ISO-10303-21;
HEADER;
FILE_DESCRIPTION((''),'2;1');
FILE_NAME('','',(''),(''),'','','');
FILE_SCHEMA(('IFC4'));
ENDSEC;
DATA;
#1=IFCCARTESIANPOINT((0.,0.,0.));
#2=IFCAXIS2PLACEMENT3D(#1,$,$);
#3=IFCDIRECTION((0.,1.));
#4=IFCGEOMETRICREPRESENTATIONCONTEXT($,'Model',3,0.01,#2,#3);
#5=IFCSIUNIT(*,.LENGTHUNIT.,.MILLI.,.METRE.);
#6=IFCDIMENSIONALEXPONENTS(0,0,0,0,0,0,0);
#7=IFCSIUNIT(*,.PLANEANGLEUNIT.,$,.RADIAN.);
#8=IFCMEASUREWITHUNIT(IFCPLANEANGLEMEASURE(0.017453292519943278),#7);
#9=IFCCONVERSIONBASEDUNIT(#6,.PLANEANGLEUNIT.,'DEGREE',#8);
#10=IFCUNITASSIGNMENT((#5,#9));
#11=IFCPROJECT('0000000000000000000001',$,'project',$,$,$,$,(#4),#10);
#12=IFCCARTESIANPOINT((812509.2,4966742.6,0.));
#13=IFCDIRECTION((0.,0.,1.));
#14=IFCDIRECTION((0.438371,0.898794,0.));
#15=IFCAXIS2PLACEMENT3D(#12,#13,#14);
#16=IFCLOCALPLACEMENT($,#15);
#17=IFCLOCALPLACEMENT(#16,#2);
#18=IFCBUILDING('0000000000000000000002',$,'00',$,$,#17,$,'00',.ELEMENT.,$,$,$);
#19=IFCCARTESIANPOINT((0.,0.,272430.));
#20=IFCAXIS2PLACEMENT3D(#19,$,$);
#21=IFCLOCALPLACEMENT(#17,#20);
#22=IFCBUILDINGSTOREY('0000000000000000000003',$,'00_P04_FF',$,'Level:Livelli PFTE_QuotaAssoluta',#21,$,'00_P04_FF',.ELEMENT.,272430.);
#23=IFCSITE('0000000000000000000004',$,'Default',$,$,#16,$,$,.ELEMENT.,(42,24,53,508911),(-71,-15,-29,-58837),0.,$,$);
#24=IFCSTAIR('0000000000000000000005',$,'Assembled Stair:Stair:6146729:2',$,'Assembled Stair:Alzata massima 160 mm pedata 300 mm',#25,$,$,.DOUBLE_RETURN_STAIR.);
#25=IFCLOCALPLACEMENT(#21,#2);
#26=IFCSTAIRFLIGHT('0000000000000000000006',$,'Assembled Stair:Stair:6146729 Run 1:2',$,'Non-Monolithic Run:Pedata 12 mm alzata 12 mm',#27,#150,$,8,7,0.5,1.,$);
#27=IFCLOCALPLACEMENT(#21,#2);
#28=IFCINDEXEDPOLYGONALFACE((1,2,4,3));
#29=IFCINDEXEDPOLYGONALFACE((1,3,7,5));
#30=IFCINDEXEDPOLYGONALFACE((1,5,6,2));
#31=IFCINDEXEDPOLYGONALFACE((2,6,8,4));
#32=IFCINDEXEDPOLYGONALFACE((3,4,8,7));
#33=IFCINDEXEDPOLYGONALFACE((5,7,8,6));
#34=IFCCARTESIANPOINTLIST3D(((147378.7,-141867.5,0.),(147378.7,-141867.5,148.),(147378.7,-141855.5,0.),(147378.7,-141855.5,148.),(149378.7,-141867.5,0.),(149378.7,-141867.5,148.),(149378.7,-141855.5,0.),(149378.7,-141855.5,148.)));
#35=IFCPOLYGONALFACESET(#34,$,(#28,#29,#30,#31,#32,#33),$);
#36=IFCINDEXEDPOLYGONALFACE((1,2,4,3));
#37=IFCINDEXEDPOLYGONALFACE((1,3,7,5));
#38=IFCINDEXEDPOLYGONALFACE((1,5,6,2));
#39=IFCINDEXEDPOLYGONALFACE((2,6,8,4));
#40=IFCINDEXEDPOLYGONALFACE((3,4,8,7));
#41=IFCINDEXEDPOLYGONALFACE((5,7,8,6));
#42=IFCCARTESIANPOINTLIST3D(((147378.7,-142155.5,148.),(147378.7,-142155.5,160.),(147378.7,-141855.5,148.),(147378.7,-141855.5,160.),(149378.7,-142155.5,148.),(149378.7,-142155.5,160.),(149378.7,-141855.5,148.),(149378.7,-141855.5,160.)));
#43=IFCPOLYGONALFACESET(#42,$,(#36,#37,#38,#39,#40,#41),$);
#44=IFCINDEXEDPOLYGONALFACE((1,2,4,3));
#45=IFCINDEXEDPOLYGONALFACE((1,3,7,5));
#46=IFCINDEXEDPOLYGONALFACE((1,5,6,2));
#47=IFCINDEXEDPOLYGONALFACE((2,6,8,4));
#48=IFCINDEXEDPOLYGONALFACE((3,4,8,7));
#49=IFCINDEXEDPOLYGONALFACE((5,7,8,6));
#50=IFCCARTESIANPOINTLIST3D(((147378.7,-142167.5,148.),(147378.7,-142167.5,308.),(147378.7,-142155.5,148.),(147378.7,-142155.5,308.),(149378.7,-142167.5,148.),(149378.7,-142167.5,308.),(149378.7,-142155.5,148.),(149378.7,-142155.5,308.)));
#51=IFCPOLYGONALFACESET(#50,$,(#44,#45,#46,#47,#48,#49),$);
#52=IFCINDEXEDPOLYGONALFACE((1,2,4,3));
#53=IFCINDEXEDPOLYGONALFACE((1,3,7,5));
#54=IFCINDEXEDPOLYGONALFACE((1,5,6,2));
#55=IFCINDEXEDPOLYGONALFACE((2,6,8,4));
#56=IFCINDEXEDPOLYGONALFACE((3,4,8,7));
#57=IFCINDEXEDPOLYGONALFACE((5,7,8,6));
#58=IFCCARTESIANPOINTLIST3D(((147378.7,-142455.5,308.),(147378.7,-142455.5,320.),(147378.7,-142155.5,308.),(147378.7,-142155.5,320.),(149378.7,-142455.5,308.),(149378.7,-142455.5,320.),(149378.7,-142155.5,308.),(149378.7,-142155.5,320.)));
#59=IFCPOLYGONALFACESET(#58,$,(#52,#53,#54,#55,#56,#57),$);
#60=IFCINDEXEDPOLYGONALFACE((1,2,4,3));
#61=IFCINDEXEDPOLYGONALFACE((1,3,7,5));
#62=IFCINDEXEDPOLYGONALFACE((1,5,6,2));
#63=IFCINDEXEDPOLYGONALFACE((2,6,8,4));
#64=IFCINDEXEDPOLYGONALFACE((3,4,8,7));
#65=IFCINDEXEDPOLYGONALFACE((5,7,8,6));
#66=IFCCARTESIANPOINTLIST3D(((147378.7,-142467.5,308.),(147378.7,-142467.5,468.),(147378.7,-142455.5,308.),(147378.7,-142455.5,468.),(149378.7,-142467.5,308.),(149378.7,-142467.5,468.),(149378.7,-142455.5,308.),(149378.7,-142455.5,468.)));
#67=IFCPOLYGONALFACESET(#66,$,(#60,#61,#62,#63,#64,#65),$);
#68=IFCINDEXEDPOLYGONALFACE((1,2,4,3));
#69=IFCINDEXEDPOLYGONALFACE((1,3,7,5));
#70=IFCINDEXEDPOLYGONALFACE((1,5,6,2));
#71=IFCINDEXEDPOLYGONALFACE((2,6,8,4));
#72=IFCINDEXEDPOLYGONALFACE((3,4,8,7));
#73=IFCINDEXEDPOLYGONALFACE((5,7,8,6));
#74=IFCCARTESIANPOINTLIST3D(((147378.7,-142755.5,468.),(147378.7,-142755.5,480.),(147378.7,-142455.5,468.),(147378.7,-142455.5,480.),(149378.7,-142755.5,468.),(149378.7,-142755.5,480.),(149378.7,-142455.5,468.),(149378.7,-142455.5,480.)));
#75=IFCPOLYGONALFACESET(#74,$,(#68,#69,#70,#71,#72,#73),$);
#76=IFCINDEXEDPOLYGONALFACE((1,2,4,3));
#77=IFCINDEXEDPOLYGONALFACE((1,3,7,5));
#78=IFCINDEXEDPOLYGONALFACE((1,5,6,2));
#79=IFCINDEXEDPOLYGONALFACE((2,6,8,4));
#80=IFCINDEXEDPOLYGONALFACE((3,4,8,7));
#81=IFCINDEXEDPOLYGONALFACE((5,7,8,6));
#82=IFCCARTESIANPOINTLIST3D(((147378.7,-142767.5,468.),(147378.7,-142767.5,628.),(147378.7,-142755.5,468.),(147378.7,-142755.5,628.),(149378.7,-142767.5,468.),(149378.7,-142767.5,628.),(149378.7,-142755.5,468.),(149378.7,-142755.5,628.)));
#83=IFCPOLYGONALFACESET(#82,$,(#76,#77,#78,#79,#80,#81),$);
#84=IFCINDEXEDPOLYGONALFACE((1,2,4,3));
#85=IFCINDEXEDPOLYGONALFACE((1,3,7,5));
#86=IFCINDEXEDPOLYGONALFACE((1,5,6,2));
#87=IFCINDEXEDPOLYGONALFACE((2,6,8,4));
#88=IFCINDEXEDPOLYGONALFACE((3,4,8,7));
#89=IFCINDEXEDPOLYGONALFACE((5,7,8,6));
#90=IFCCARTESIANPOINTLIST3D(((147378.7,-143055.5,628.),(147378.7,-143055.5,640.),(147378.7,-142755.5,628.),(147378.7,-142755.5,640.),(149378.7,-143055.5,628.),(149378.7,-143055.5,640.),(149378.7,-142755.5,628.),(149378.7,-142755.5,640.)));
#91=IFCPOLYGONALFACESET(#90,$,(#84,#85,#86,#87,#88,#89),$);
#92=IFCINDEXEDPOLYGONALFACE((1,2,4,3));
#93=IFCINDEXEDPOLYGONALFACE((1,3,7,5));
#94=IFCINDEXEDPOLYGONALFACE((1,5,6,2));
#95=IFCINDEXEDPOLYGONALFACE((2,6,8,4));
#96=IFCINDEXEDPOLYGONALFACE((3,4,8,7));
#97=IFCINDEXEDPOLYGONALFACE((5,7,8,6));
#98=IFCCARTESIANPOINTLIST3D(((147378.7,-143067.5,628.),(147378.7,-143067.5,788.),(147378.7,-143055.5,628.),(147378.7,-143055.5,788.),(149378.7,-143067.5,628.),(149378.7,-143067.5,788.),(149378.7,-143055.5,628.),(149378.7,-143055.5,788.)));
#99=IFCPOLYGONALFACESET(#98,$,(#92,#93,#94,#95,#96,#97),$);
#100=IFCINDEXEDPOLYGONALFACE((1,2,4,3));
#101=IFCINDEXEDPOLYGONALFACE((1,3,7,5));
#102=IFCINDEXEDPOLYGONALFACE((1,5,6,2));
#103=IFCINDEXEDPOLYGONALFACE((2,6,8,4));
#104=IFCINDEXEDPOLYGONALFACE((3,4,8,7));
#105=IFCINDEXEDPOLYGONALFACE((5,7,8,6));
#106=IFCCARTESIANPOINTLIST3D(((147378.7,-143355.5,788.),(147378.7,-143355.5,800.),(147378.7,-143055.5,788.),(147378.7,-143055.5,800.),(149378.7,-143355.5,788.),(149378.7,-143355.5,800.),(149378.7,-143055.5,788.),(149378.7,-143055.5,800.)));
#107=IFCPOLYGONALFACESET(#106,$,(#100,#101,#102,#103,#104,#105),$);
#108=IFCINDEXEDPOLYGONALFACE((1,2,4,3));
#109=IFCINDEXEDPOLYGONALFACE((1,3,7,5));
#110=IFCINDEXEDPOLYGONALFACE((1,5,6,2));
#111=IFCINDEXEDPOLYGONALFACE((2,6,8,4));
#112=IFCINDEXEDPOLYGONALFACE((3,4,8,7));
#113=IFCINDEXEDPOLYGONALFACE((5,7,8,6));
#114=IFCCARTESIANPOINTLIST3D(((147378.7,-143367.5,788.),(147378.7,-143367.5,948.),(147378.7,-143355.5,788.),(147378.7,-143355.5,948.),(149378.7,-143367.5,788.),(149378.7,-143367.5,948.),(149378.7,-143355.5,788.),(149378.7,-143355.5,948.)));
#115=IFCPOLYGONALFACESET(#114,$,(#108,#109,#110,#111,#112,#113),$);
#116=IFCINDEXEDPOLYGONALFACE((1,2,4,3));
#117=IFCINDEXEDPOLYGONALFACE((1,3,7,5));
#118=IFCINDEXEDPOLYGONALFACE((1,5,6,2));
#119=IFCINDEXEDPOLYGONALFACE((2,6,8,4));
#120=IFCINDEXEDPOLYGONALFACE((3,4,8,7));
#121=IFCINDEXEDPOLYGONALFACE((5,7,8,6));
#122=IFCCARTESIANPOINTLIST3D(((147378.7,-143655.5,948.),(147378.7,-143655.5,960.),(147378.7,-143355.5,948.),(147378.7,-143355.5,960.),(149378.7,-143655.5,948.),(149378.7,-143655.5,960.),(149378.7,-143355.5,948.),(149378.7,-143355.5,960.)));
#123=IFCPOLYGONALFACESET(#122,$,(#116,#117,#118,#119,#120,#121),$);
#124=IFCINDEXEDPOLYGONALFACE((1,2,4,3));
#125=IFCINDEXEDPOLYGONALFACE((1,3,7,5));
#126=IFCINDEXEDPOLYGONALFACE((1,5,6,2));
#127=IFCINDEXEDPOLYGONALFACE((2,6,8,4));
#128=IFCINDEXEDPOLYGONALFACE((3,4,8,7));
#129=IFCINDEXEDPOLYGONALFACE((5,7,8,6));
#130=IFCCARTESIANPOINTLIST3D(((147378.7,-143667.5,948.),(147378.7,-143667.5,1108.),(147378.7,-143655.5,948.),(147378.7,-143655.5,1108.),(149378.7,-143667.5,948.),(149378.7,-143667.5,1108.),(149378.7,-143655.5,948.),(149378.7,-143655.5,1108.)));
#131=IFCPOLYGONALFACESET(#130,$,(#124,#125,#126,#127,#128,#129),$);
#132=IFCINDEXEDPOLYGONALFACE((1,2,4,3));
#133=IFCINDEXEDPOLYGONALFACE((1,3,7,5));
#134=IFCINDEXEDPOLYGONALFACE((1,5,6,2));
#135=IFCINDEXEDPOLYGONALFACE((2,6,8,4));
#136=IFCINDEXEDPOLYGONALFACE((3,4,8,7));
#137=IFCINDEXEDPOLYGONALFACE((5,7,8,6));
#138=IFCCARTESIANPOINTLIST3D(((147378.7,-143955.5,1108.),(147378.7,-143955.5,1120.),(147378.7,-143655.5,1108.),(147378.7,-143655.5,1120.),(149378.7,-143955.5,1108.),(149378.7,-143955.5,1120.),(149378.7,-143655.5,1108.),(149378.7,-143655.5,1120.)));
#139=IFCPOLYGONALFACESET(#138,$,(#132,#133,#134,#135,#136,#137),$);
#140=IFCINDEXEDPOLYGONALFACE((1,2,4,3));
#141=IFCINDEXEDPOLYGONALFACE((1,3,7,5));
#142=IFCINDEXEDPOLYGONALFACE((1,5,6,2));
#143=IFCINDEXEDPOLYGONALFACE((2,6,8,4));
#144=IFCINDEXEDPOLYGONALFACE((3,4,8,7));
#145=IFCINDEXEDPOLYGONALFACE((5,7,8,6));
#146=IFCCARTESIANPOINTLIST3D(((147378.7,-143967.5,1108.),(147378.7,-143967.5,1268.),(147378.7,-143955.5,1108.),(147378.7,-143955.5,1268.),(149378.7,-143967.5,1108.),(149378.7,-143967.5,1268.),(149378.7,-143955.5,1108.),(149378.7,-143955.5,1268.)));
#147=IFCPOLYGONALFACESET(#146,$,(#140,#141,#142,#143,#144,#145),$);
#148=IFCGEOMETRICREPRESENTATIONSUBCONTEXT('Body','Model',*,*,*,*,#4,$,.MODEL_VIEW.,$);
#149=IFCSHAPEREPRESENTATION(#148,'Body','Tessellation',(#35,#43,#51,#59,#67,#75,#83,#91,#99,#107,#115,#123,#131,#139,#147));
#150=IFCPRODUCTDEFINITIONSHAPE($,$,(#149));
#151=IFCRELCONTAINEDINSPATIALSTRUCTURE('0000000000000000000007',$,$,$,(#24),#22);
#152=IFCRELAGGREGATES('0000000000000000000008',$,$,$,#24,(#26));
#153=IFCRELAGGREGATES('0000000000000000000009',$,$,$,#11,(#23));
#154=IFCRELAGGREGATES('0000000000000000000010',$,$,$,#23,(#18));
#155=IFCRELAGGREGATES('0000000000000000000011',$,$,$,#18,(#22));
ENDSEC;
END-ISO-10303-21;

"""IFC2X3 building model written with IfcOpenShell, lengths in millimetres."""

from ifc_helpers import new_model, entity, si_unit, converted_unit, direction, frame, origin, origin_2d_with_axis, place, context, subcontext, project, spatial, rectangle, extrude, element, aggregate, save


model = new_model("IFC2X3")

# Units and contexts
model_context = context("Model", 3, precision=0.01, world=origin(), true_north=direction((0.0, 1.0)))
body_context = subcontext(model_context, "Body", "Model", "MODEL_VIEW")
ifc_project = project(units=[si_unit("LENGTHUNIT", "METRE", prefix="MILLI"), converted_unit("PLANEANGLEUNIT", "DEGREE", entity("IfcPlaneAngleMeasure", 0.017453292519943278), si_unit("PLANEANGLEUNIT", "RADIAN"), dimensions=[0, 0, 0, 0, 0, 0, 0])], contexts=[model_context])

# Site, building, storey
site_placement = place(None, frame((812509.2, 4966742.6, 0.0), z_axis=(0.0, 0.0, 1.0), x_axis=(0.438371, 0.898794, 0.0)))
site = spatial("IfcSite", under=ifc_project, at=site_placement, Name="Default", CompositionType="ELEMENT", RefLatitude=(42, 24, 53, 508911), RefLongitude=(-71, -15, -29, -58837), RefElevation=0.0)
building_placement = place(site_placement, origin())
building = spatial("IfcBuilding", under=site, at=building_placement, Name="00", LongName="00", CompositionType="ELEMENT")
storey_placement = place(building_placement, frame((0.0, 0.0, 272430.0)))
storey = spatial("IfcBuildingStorey", under=building, at=storey_placement, Name="00_P04_FF", ObjectType="Level:Livelli PFTE_QuotaAssoluta", LongName="00_P04_FF", CompositionType="ELEMENT", Elevation=272430.0)

# Stair
stair_1_placement = place(storey_placement, origin())
stair_1 = element("IfcStair", 1, at=stair_1_placement, inside=storey, Name="Assembled Stair:Stair:6146729:2", ObjectType="Assembled Stair:Alzata massima 160 mm pedata 300 mm", ShapeType="DOUBLE_RETURN_STAIR")

# Stair flight
stair_flight_1_placement = place(stair_1_placement, origin())
stair_flight_1 = element("IfcStairFlight", 2, at=stair_flight_1_placement, Name="Assembled Stair:Stair:6146729 Run 1:2", ObjectType="Non-Monolithic Run:Pedata 12 mm alzata 12 mm", NumberOfRiser=8, NumberOfTreads=7, RiserHeight=0.5, TreadLength=1.0, context=body_context, shape_type="SweptSolid", body=[
    extrude(rectangle(XDim=2000.0, YDim=12.0, at=origin_2d_with_axis()), frame((148378.7, -141861.5, 0.0)), (0.0, 0.0, 1.0), 148.0),
    extrude(rectangle(XDim=300.0, YDim=2000.0, at=origin_2d_with_axis()), frame((148378.7, -142005.5, 148.0), z_axis=(0.0, 0.0, 1.0), x_axis=(0.0, 1.0, 0.0)), (0.0, 0.0, 1.0), 12.0),
    extrude(rectangle(XDim=2000.0, YDim=12.0, at=origin_2d_with_axis()), frame((148378.7, -142161.5, 148.0)), (0.0, 0.0, 1.0), 160.0),
    extrude(rectangle(XDim=300.0, YDim=2000.0, at=origin_2d_with_axis()), frame((148378.7, -142305.5, 308.0), z_axis=(0.0, 0.0, 1.0), x_axis=(0.0, 1.0, 0.0)), (0.0, 0.0, 1.0), 12.0),
    extrude(rectangle(XDim=2000.0, YDim=12.0, at=origin_2d_with_axis()), frame((148378.7, -142461.5, 308.0)), (0.0, 0.0, 1.0), 160.0),
    extrude(rectangle(XDim=300.0, YDim=2000.0, at=origin_2d_with_axis()), frame((148378.7, -142605.5, 468.0), z_axis=(0.0, 0.0, 1.0), x_axis=(0.0, 1.0, 0.0)), (0.0, 0.0, 1.0), 12.0),
    extrude(rectangle(XDim=2000.0, YDim=12.0, at=origin_2d_with_axis()), frame((148378.7, -142761.5, 468.0)), (0.0, 0.0, 1.0), 160.0),
    extrude(rectangle(XDim=300.0, YDim=2000.0, at=origin_2d_with_axis()), frame((148378.7, -142905.5, 628.0), z_axis=(0.0, 0.0, 1.0), x_axis=(0.0, 1.0, 0.0)), (0.0, 0.0, 1.0), 12.0),
    extrude(rectangle(XDim=2000.0, YDim=12.0, at=origin_2d_with_axis()), frame((148378.7, -143061.5, 628.0)), (0.0, 0.0, 1.0), 160.0),
    extrude(rectangle(XDim=300.0, YDim=2000.0, at=origin_2d_with_axis()), frame((148378.7, -143205.5, 788.0), z_axis=(0.0, 0.0, 1.0), x_axis=(0.0, 1.0, 0.0)), (0.0, 0.0, 1.0), 12.0),
    extrude(rectangle(XDim=2000.0, YDim=12.0, at=origin_2d_with_axis()), frame((148378.7, -143361.5, 788.0)), (0.0, 0.0, 1.0), 160.0),
    extrude(rectangle(XDim=300.0, YDim=2000.0, at=origin_2d_with_axis()), frame((148378.7, -143505.5, 948.0), z_axis=(0.0, 0.0, 1.0), x_axis=(0.0, 1.0, 0.0)), (0.0, 0.0, 1.0), 12.0),
    extrude(rectangle(XDim=2000.0, YDim=12.0, at=origin_2d_with_axis()), frame((148378.7, -143661.5, 948.0)), (0.0, 0.0, 1.0), 160.0),
    extrude(rectangle(XDim=300.0, YDim=2000.0, at=origin_2d_with_axis()), frame((148378.7, -143805.5, 1108.0), z_axis=(0.0, 0.0, 1.0), x_axis=(0.0, 1.0, 0.0)), (0.0, 0.0, 1.0), 12.0),
    extrude(rectangle(XDim=2000.0, YDim=12.0, at=origin_2d_with_axis()), frame((148378.7, -143961.5, 1108.0)), (0.0, 0.0, 1.0), 160.0),
])
aggregate(stair_1, [stair_flight_1])

save(model, "model.ifc")
